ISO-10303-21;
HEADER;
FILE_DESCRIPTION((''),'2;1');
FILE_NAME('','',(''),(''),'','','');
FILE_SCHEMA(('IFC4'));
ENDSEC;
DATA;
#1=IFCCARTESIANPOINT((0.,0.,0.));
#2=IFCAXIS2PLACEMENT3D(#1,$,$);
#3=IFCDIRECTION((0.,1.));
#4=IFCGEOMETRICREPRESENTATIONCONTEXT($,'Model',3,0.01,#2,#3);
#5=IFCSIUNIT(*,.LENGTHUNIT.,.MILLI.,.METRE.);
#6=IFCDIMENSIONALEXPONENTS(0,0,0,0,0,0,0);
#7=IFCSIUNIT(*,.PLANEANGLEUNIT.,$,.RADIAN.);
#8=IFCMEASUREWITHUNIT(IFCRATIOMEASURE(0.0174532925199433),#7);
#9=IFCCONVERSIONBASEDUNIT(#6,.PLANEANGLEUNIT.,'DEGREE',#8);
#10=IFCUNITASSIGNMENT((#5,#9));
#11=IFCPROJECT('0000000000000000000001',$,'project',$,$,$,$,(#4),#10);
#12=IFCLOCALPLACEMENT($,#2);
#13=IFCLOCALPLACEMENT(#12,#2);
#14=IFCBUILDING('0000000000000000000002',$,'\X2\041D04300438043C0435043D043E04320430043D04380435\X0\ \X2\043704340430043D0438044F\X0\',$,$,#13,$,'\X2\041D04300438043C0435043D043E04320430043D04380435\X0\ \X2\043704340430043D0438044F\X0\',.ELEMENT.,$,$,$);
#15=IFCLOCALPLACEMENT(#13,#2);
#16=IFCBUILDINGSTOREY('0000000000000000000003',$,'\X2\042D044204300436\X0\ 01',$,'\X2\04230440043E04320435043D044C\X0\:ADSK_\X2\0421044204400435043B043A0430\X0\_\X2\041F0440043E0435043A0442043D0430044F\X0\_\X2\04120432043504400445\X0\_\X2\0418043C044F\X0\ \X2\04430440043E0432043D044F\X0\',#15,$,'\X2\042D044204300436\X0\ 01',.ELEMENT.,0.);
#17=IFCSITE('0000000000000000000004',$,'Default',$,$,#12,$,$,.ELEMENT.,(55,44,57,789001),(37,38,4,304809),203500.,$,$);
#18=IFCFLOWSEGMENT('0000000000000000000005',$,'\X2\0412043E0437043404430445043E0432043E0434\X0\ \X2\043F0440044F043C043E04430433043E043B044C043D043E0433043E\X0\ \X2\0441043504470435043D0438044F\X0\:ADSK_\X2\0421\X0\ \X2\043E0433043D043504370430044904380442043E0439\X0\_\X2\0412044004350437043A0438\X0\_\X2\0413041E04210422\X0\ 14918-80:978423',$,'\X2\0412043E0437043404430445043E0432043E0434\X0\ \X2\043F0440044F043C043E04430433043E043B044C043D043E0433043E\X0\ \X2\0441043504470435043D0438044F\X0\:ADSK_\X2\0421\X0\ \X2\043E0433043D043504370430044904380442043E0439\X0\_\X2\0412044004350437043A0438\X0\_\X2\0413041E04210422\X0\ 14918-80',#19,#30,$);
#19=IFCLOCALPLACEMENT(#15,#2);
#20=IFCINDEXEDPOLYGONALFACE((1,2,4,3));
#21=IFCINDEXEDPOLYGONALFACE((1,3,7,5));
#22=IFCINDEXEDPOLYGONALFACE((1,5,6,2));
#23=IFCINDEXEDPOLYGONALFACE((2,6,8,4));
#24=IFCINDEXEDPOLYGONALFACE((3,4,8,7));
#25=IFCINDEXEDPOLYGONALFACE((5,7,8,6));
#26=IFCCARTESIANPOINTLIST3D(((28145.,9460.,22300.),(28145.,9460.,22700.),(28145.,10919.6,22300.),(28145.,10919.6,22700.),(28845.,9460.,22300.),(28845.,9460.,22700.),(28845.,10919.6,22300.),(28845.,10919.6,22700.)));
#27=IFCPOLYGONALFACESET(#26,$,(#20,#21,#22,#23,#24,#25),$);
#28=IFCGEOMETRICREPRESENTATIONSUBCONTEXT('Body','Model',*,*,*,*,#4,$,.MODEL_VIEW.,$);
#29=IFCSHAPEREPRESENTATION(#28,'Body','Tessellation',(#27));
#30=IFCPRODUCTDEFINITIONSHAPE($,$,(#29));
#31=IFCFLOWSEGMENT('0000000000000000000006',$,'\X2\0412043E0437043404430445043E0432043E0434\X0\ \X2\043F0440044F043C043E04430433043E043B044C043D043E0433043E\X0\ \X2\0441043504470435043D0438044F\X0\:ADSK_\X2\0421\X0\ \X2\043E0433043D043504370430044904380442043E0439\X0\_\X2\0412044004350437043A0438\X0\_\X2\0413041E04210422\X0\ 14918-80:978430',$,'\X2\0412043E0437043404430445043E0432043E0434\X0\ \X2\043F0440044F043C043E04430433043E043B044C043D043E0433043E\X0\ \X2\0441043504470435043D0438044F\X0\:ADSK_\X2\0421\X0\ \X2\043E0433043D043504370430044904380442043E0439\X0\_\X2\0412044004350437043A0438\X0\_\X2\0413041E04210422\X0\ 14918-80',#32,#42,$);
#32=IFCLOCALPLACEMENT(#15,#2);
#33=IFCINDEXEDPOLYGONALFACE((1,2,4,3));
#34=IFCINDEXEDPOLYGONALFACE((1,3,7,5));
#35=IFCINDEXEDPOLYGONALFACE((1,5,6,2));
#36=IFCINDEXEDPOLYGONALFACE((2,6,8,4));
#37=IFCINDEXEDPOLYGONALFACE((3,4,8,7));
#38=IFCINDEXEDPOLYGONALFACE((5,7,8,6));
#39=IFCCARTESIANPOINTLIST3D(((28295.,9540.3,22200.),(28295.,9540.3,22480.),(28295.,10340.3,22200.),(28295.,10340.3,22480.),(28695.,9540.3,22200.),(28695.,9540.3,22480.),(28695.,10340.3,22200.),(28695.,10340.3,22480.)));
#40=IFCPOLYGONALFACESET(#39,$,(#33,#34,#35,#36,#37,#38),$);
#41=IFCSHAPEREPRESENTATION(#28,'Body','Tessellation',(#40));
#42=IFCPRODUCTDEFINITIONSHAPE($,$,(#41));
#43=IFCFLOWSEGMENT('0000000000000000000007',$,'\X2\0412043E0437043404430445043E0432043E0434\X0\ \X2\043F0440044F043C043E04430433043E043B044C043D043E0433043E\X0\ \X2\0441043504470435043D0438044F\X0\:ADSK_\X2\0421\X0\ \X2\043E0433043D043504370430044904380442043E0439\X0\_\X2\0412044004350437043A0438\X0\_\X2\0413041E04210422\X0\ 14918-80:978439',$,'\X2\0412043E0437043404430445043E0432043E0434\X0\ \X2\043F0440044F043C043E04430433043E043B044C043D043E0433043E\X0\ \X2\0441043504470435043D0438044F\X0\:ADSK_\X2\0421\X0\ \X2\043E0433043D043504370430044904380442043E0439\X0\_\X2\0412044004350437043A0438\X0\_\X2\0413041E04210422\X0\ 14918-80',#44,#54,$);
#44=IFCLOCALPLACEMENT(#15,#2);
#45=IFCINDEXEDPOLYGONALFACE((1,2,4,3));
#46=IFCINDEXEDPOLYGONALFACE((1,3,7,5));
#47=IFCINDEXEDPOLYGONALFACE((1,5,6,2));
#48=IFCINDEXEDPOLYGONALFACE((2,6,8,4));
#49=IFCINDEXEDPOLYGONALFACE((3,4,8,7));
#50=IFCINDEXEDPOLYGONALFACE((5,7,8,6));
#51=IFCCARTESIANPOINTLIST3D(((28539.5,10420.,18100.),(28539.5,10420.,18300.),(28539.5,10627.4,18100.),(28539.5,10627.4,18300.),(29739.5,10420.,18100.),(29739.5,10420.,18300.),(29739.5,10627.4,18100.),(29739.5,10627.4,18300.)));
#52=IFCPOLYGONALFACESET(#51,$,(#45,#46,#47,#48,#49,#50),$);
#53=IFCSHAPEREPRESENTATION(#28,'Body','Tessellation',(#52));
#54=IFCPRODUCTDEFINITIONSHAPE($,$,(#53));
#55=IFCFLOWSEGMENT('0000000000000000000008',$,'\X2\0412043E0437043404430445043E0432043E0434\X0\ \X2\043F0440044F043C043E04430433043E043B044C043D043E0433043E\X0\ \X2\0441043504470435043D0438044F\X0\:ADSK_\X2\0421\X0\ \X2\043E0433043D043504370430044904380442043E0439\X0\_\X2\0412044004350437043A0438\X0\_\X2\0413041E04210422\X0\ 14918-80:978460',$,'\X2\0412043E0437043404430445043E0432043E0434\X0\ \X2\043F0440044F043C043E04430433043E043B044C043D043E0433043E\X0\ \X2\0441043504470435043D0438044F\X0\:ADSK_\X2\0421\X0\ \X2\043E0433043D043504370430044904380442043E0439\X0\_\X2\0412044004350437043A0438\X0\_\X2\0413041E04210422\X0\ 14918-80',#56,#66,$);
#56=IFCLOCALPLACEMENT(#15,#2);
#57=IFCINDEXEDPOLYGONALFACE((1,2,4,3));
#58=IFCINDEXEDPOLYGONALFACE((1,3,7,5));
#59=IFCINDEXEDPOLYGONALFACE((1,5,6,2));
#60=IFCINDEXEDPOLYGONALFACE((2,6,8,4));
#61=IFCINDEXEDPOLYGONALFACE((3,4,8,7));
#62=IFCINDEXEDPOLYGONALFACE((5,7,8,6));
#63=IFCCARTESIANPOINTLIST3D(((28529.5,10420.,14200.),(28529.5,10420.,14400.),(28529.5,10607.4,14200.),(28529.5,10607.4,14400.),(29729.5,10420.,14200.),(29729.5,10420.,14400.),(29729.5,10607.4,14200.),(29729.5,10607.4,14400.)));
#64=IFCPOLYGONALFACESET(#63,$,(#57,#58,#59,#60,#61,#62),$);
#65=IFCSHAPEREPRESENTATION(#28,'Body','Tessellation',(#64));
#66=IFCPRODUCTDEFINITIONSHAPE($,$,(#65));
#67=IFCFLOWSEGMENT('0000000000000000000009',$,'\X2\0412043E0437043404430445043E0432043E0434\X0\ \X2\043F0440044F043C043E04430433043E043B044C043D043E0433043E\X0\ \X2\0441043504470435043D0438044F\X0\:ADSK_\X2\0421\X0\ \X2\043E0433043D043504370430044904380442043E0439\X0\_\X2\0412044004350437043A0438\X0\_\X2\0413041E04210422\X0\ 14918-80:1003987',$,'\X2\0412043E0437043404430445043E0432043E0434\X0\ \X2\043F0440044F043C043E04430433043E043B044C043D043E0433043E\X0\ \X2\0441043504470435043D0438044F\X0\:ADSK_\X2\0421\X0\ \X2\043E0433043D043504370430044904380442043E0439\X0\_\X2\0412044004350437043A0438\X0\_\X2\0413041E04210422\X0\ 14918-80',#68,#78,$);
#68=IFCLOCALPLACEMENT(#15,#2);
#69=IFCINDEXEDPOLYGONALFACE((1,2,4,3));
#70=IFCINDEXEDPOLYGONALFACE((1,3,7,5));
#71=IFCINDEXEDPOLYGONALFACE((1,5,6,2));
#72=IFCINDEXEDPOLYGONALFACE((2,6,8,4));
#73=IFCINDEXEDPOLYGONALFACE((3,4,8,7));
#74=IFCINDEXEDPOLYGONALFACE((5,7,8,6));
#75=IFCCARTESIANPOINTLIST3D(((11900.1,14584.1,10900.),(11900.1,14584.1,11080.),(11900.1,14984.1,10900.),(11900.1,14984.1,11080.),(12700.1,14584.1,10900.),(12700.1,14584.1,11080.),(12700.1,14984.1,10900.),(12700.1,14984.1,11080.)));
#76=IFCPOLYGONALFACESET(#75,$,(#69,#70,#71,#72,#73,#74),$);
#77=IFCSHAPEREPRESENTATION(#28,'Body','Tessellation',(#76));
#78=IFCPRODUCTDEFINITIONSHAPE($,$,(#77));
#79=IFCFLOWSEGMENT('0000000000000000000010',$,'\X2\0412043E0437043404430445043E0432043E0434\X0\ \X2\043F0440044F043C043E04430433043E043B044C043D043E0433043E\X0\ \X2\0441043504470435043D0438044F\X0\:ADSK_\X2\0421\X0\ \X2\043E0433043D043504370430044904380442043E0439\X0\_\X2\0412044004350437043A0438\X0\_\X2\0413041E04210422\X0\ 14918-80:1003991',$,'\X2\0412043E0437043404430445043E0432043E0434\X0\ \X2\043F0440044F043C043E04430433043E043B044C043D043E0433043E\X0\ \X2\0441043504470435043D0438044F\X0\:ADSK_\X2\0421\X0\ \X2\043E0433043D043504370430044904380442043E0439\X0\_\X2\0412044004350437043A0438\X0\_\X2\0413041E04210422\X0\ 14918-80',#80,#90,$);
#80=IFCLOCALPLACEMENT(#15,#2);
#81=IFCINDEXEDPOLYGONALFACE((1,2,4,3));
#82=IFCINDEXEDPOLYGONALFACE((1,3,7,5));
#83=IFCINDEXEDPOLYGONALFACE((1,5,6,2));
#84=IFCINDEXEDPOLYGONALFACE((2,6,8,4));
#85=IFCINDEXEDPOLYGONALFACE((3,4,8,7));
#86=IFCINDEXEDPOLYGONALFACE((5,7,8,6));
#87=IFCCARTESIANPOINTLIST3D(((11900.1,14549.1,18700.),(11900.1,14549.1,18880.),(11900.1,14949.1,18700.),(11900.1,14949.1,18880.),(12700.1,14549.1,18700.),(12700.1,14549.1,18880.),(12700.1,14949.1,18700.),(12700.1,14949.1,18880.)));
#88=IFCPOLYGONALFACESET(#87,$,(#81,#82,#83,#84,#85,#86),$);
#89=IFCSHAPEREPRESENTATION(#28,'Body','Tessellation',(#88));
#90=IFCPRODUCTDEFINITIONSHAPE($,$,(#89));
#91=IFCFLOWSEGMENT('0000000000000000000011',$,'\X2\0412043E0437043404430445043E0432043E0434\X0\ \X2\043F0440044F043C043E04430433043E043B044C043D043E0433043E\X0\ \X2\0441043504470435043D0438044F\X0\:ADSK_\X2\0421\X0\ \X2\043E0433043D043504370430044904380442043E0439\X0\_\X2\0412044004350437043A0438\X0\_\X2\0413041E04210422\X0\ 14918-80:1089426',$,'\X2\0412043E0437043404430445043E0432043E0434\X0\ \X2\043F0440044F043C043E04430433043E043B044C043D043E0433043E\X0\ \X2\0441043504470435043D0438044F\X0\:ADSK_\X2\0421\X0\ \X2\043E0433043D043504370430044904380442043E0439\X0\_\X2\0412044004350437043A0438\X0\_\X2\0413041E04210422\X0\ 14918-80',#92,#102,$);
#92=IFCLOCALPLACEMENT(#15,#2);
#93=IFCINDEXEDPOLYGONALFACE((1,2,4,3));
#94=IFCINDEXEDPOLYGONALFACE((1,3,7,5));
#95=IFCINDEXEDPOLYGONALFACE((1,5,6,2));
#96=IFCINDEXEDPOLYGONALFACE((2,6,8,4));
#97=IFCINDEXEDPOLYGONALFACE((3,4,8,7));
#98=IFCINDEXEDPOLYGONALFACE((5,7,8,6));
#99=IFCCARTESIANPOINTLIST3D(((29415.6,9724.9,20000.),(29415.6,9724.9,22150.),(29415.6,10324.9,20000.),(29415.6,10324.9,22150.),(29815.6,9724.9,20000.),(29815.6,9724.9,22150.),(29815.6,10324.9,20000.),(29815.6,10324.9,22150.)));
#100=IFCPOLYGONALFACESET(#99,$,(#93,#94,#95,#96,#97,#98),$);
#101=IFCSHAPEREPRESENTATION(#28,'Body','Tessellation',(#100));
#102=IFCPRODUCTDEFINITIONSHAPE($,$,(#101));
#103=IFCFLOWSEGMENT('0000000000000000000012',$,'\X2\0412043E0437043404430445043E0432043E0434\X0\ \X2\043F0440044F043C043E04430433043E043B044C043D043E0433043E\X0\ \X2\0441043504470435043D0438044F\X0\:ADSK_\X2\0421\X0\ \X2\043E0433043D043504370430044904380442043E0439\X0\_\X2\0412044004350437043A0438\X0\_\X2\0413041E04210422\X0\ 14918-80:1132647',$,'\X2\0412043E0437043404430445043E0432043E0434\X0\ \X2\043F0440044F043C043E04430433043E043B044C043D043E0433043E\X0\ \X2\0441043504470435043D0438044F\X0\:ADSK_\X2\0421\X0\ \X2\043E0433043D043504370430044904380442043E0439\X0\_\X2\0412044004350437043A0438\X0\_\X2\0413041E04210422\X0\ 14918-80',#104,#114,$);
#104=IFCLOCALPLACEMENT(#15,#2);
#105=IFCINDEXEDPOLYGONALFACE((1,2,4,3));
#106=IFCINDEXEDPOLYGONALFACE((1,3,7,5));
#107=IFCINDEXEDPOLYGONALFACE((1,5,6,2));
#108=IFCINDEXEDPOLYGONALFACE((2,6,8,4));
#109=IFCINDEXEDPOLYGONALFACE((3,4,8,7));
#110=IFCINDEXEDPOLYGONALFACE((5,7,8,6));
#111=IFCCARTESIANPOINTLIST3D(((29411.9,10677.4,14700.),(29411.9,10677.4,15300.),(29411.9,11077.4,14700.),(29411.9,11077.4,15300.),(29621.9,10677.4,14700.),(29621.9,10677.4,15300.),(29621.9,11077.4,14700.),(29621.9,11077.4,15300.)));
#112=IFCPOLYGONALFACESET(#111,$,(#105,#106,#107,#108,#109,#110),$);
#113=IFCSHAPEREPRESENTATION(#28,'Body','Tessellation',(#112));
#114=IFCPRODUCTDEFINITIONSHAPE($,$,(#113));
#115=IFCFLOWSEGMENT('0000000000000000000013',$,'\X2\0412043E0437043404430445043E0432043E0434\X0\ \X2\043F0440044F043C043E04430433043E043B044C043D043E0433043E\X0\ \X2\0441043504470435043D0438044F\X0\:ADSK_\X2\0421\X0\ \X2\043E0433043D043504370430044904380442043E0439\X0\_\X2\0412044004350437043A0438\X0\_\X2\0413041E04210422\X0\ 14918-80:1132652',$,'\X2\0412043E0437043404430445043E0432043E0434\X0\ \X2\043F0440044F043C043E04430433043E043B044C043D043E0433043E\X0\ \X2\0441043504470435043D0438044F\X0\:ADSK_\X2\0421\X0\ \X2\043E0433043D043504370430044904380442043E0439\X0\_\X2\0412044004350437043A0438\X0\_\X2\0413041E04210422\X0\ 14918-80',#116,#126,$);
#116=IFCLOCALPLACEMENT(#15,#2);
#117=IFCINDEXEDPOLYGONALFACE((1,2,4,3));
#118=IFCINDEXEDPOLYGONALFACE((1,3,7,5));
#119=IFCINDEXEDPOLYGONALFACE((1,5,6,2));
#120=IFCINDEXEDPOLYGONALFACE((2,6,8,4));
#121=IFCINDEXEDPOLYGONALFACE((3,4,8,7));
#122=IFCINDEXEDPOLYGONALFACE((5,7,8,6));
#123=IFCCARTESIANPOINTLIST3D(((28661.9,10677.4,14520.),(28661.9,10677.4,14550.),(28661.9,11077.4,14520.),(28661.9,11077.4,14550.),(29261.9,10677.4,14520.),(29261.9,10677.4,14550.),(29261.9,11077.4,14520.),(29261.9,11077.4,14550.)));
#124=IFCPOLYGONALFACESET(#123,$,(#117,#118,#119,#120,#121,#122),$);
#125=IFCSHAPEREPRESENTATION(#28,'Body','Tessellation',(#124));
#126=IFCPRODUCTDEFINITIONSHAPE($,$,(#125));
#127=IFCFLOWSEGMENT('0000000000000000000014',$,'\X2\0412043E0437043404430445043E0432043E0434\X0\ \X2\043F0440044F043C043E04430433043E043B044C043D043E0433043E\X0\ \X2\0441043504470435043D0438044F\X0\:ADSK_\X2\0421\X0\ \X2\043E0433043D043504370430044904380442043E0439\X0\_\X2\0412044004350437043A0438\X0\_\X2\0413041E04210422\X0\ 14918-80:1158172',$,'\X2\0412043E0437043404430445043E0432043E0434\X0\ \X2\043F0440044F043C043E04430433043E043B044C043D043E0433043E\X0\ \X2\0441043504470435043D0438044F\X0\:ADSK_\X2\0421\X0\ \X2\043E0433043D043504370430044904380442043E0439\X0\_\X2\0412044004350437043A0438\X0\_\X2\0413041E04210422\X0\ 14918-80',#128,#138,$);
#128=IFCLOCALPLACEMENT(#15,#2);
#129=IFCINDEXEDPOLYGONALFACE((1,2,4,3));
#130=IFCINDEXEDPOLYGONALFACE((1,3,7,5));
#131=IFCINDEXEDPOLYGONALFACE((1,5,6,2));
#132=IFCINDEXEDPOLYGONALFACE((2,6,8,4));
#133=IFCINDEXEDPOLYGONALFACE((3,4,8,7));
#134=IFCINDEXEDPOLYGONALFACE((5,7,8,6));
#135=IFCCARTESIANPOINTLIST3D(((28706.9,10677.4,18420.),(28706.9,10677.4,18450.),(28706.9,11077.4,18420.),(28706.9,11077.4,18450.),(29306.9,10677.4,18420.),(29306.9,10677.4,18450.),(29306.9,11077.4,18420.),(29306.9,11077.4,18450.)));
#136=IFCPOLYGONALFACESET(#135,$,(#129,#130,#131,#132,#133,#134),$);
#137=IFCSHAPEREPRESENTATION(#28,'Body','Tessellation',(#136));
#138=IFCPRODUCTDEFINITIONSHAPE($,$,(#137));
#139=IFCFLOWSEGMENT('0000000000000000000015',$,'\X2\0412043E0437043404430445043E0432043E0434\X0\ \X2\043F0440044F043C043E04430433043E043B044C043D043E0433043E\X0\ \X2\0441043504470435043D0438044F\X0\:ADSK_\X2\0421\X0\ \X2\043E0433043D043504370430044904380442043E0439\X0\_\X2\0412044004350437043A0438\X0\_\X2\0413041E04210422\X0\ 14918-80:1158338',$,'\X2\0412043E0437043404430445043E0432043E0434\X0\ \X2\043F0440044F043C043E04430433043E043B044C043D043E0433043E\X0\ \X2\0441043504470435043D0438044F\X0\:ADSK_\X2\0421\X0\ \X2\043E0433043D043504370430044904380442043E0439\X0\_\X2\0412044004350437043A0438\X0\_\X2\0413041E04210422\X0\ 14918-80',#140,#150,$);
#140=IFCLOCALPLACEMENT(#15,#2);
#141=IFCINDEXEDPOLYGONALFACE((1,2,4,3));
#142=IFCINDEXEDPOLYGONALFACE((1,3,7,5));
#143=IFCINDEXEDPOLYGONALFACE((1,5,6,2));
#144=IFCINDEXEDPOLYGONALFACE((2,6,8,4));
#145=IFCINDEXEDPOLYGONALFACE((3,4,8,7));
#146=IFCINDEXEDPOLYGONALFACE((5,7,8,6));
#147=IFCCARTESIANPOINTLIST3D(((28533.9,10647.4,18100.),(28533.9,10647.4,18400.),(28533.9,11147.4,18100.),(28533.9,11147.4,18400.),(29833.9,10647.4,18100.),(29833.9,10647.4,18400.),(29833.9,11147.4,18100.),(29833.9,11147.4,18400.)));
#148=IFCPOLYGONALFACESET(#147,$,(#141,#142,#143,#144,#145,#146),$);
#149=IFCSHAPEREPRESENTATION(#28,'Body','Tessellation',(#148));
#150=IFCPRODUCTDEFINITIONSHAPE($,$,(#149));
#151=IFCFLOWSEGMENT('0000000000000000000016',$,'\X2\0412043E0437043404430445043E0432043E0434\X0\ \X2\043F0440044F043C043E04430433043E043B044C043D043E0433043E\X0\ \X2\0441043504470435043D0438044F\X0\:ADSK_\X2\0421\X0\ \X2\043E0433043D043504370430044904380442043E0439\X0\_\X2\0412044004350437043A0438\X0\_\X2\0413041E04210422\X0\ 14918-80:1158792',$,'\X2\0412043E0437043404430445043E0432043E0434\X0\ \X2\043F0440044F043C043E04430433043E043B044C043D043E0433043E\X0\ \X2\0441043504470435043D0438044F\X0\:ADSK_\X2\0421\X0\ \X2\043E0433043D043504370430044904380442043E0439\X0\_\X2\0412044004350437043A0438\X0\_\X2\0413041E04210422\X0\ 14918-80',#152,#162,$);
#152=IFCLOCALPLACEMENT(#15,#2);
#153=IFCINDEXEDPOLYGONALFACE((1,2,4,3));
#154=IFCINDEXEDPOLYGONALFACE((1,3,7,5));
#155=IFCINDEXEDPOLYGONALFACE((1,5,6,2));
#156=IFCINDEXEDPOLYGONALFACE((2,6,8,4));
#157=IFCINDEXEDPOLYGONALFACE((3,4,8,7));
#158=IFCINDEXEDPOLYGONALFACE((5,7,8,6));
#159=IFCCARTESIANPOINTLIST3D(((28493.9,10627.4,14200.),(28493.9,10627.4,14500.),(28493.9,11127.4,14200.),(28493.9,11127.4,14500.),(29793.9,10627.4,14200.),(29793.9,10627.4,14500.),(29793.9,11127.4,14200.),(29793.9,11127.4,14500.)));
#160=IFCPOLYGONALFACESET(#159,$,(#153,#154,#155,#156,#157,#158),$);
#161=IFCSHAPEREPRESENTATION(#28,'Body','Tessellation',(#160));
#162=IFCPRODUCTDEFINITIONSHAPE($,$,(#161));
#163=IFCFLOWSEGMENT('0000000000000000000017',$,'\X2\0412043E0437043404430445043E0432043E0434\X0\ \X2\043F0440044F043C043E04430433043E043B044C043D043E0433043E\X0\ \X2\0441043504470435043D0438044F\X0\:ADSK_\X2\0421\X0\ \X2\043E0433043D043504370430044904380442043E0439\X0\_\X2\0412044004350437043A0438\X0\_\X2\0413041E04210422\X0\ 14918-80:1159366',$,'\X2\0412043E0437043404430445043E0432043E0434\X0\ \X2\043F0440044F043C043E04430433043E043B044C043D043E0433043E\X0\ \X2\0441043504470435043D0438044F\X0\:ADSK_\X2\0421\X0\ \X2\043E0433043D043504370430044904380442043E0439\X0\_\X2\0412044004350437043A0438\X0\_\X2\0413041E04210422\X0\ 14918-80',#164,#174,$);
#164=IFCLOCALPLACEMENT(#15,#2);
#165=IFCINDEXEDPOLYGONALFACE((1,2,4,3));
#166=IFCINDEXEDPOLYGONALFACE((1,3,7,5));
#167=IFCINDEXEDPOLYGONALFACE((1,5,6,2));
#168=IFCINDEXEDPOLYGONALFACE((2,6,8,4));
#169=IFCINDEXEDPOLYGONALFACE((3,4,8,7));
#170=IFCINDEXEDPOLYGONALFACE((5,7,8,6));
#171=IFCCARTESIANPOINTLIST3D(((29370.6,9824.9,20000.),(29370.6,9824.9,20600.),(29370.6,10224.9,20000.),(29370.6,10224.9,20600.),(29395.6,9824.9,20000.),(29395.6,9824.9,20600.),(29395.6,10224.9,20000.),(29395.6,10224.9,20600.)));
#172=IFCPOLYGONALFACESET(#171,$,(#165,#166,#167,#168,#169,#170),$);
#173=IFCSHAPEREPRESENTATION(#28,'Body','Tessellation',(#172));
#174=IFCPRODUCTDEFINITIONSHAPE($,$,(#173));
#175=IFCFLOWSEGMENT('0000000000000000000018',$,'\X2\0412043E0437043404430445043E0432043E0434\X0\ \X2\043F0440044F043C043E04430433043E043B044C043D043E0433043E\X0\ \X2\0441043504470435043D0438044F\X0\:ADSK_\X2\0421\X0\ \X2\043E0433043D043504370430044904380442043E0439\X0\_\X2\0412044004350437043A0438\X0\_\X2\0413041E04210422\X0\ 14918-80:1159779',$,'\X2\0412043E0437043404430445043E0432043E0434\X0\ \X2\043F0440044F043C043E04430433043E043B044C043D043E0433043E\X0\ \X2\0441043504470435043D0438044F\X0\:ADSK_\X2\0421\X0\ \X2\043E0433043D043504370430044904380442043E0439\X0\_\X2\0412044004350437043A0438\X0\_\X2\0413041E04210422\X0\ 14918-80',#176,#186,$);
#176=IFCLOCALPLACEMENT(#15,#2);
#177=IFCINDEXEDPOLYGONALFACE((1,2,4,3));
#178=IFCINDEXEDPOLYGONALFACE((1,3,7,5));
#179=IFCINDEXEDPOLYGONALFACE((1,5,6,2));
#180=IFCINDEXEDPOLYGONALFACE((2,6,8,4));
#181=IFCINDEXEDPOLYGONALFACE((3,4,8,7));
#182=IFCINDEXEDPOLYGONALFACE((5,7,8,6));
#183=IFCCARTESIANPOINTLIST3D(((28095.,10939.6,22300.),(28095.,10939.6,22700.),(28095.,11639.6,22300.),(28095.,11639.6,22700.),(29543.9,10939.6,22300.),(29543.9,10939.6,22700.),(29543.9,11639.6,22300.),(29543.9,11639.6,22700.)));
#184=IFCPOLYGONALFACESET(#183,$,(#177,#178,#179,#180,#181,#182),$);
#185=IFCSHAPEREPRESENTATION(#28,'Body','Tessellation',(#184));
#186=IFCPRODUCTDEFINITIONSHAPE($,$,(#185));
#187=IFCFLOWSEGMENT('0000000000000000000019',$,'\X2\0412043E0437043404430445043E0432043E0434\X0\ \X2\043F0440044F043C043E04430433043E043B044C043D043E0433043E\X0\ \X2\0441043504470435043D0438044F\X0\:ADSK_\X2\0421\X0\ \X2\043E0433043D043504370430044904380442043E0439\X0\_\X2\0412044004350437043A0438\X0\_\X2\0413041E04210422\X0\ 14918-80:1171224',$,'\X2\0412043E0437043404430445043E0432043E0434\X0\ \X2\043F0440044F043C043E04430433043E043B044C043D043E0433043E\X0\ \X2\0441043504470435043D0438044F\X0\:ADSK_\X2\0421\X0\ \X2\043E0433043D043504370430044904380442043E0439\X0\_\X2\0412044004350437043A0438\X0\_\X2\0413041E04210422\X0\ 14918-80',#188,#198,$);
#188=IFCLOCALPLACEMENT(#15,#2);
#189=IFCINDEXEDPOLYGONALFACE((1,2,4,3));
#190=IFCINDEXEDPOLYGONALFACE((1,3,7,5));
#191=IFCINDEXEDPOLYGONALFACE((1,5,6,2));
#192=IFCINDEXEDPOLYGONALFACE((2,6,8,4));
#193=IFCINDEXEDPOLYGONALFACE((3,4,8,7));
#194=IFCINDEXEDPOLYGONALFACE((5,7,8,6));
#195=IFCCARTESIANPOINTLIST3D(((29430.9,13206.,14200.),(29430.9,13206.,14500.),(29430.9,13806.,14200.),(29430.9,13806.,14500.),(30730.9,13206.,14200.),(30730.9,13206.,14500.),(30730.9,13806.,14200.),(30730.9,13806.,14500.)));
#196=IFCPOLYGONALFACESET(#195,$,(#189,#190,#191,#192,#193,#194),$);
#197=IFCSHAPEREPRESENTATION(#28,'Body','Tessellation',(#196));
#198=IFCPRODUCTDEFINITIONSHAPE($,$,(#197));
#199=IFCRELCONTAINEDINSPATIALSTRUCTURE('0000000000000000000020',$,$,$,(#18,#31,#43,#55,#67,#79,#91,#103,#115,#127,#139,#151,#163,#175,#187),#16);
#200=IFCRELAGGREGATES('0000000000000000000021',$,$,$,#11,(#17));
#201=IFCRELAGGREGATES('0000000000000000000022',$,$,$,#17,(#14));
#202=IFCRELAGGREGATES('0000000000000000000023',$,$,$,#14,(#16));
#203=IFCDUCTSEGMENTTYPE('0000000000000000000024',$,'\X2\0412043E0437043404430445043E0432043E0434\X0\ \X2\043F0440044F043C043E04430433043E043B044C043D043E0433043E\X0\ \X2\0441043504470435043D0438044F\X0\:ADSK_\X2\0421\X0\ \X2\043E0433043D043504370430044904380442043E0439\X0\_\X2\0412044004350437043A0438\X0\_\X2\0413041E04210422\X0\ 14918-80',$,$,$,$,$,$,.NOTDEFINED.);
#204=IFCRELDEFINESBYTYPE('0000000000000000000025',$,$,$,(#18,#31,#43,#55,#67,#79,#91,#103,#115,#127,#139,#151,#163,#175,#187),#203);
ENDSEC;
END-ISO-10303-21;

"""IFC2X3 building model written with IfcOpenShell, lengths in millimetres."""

from ifc_helpers import new_model, entity, si_unit, converted_unit, direction, frame, frame_2d, origin, origin_2d_with_axis, place, context, subcontext, project, spatial, rectangle, extrude, type_object, element, save


model = new_model("IFC2X3")

# Units and contexts
model_context = context("Model", 3, precision=0.01, world=origin(), true_north=direction((0.0, 1.0)))
body_context = subcontext(model_context, "Body", "Model", "MODEL_VIEW")
ifc_project = project(units=[si_unit("LENGTHUNIT", "METRE", prefix="MILLI"), converted_unit("PLANEANGLEUNIT", "DEGREE", entity("IfcRatioMeasure", 0.0174532925199433), si_unit("PLANEANGLEUNIT", "RADIAN"), dimensions=[0, 0, 0, 0, 0, 0, 0])], contexts=[model_context])

# Site, building, storey
site_placement = place(None, frame((0.0, 0.0, 0.0)))
site = spatial("IfcSite", under=ifc_project, at=site_placement, Name="Default", CompositionType="ELEMENT", RefLatitude=(55, 44, 57, 789001), RefLongitude=(37, 38, 4, 304809), RefElevation=203500.0)
building_placement = place(site_placement, origin())
building = spatial("IfcBuilding", under=site, at=building_placement, Name="Наименование здания", LongName="Наименование здания", CompositionType="ELEMENT")
storey_placement = place(building_placement, origin())
storey = spatial("IfcBuildingStorey", under=building, at=storey_placement, Name="Этаж 01", ObjectType="Уровень:ADSK_Стрелка_Проектная_Вверх_Имя уровня", LongName="Этаж 01", CompositionType="ELEMENT", Elevation=0.0)

# Flow segments
duct_segment_type = type_object("IfcDuctSegmentType", Name="Воздуховод прямоугольного сечения:ADSK_С огнезащитой_Врезки_ГОСТ 14918-80", PredefinedType="NOTDEFINED")
flow_segment_1_placement = place(storey_placement, frame((28145.0, 9460.0, 22300.0)))
element("IfcFlowSegment", 1, at=flow_segment_1_placement, inside=storey, type_object=duct_segment_type, Name="Воздуховод прямоугольного сечения:ADSK_С огнезащитой_Врезки_ГОСТ 14918-80:978423", ObjectType="Воздуховод прямоугольного сечения:ADSK_С огнезащитой_Врезки_ГОСТ 14918-80", context=body_context, shape_type="SweptSolid", body=[
    extrude(rectangle(XDim=1459.6, YDim=700.0, at=frame_2d((0.0, 0.0), x_axis=(1.0, 0.0))), frame((350.0, 729.8, 0.0), z_axis=(0.0, 0.0, 1.0), x_axis=(0.0, 1.0, 0.0)), (0.0, 0.0, 1.0), 400.0),
])
flow_segment_2_placement = place(storey_placement, frame((28295.0, 9540.3, 22200.0)))
element("IfcFlowSegment", 2, at=flow_segment_2_placement, inside=storey, type_object=duct_segment_type, Name="Воздуховод прямоугольного сечения:ADSK_С огнезащитой_Врезки_ГОСТ 14918-80:978430", ObjectType="Воздуховод прямоугольного сечения:ADSK_С огнезащитой_Врезки_ГОСТ 14918-80", context=body_context, shape_type="SweptSolid", body=[
    extrude(rectangle(XDim=800.0, YDim=400.0, at=frame_2d((0.0, 0.0), x_axis=(1.0, 0.0))), frame((200.0, 400.0, 0.0), z_axis=(0.0, 0.0, 1.0), x_axis=(0.0, 1.0, 0.0)), (0.0, 0.0, 1.0), 280.0),
])
flow_segment_3_placement = place(storey_placement, frame((28539.5, 10420.0, 18100.0)))
element("IfcFlowSegment", 3, at=flow_segment_3_placement, inside=storey, type_object=duct_segment_type, Name="Воздуховод прямоугольного сечения:ADSK_С огнезащитой_Врезки_ГОСТ 14918-80:978439", ObjectType="Воздуховод прямоугольного сечения:ADSK_С огнезащитой_Врезки_ГОСТ 14918-80", context=body_context, shape_type="SweptSolid", body=[
    extrude(rectangle(XDim=207.4, YDim=1200.0, at=frame_2d((0.0, 0.0), x_axis=(1.0, 0.0))), frame((600.0, 103.7, 0.0), z_axis=(0.0, 0.0, 1.0), x_axis=(0.0, 1.0, 0.0)), (0.0, 0.0, 1.0), 200.0),
])
flow_segment_4_placement = place(storey_placement, frame((28529.5, 10420.0, 14200.0)))
element("IfcFlowSegment", 4, at=flow_segment_4_placement, inside=storey, type_object=duct_segment_type, Name="Воздуховод прямоугольного сечения:ADSK_С огнезащитой_Врезки_ГОСТ 14918-80:978460", ObjectType="Воздуховод прямоугольного сечения:ADSK_С огнезащитой_Врезки_ГОСТ 14918-80", context=body_context, shape_type="SweptSolid", body=[
    extrude(rectangle(XDim=187.4, YDim=1200.0, at=frame_2d((0.0, 0.0), x_axis=(1.0, 0.0))), frame((600.0, 93.7, 0.0), z_axis=(0.0, 0.0, 1.0), x_axis=(0.0, 1.0, 0.0)), (0.0, 0.0, 1.0), 200.0),
])
flow_segment_5_placement = place(storey_placement, frame((11900.1, 14584.1, 10900.0)))
element("IfcFlowSegment", 5, at=flow_segment_5_placement, inside=storey, type_object=duct_segment_type, Name="Воздуховод прямоугольного сечения:ADSK_С огнезащитой_Врезки_ГОСТ 14918-80:1003987", ObjectType="Воздуховод прямоугольного сечения:ADSK_С огнезащитой_Врезки_ГОСТ 14918-80", context=body_context, shape_type="SweptSolid", body=[
    extrude(rectangle(XDim=400.0, YDim=800.0, at=frame_2d((0.0, 0.0), x_axis=(1.0, 0.0))), frame((400.0, 200.0, 0.0), z_axis=(0.0, 0.0, 1.0), x_axis=(0.0, 1.0, 0.0)), (0.0, 0.0, 1.0), 180.0),
])
flow_segment_6_placement = place(storey_placement, frame((11900.1, 14549.1, 18700.0)))
element("IfcFlowSegment", 6, at=flow_segment_6_placement, inside=storey, type_object=duct_segment_type, Name="Воздуховод прямоугольного сечения:ADSK_С огнезащитой_Врезки_ГОСТ 14918-80:1003991", ObjectType="Воздуховод прямоугольного сечения:ADSK_С огнезащитой_Врезки_ГОСТ 14918-80", context=body_context, shape_type="SweptSolid", body=[
    extrude(rectangle(XDim=800.0, YDim=400.0, at=origin_2d_with_axis()), frame((400.0, 200.0, 0.0)), (0.0, 0.0, 1.0), 180.0),
])
flow_segment_7_placement = place(storey_placement, frame((29415.6, 9724.9, 20000.0)))
element("IfcFlowSegment", 7, at=flow_segment_7_placement, inside=storey, type_object=duct_segment_type, Name="Воздуховод прямоугольного сечения:ADSK_С огнезащитой_Врезки_ГОСТ 14918-80:1089426", ObjectType="Воздуховод прямоугольного сечения:ADSK_С огнезащитой_Врезки_ГОСТ 14918-80", context=body_context, shape_type="SweptSolid", body=[
    extrude(rectangle(XDim=600.0, YDim=400.0, at=frame_2d((0.0, 0.0), x_axis=(1.0, 0.0))), frame((200.0, 300.0, 0.0), z_axis=(0.0, 0.0, 1.0), x_axis=(0.0, 1.0, 0.0)), (0.0, 0.0, 1.0), 2150.0),
])
flow_segment_8_placement = place(storey_placement, frame((29411.9, 10677.4, 14700.0)))
element("IfcFlowSegment", 8, at=flow_segment_8_placement, inside=storey, type_object=duct_segment_type, Name="Воздуховод прямоугольного сечения:ADSK_С огнезащитой_Врезки_ГОСТ 14918-80:1132647", ObjectType="Воздуховод прямоугольного сечения:ADSK_С огнезащитой_Врезки_ГОСТ 14918-80", context=body_context, shape_type="SweptSolid", body=[
    extrude(rectangle(XDim=210.0, YDim=400.0, at=frame_2d((0.0, 0.0), x_axis=(1.0, 0.0))), frame((105.0, 200.0, 0.0), z_axis=(0.0, 0.0, 1.0), x_axis=(-1.0, 0.0, 0.0)), (0.0, 0.0, 1.0), 600.0),
])
flow_segment_9_placement = place(storey_placement, frame((28661.9, 10677.4, 14520.0)))
element("IfcFlowSegment", 9, at=flow_segment_9_placement, inside=storey, type_object=duct_segment_type, Name="Воздуховод прямоугольного сечения:ADSK_С огнезащитой_Врезки_ГОСТ 14918-80:1132652", ObjectType="Воздуховод прямоугольного сечения:ADSK_С огнезащитой_Врезки_ГОСТ 14918-80", context=body_context, shape_type="SweptSolid", body=[
    extrude(rectangle(XDim=400.0, YDim=600.0, at=frame_2d((0.0, 0.0), x_axis=(1.0, 0.0))), frame((300.0, 200.0, 0.0), z_axis=(0.0, 0.0, 1.0), x_axis=(0.0, 1.0, 0.0)), (0.0, 0.0, 1.0), 30.0),
])
flow_segment_10_placement = place(storey_placement, frame((28706.9, 10677.4, 18420.0)))
element("IfcFlowSegment", 10, at=flow_segment_10_placement, inside=storey, type_object=duct_segment_type, Name="Воздуховод прямоугольного сечения:ADSK_С огнезащитой_Врезки_ГОСТ 14918-80:1158172", ObjectType="Воздуховод прямоугольного сечения:ADSK_С огнезащитой_Врезки_ГОСТ 14918-80", context=body_context, shape_type="SweptSolid", body=[
    extrude(rectangle(XDim=400.0, YDim=600.0, at=origin_2d_with_axis()), frame((300.0, 200.0, 0.0), z_axis=(0.0, 0.0, 1.0), x_axis=(0.0, 1.0, 0.0)), (0.0, 0.0, 1.0), 30.0),
])
flow_segment_11_placement = place(storey_placement, frame((28533.9, 10647.4, 18100.0)))
element("IfcFlowSegment", 11, at=flow_segment_11_placement, inside=storey, type_object=duct_segment_type, Name="Воздуховод прямоугольного сечения:ADSK_С огнезащитой_Врезки_ГОСТ 14918-80:1158338", ObjectType="Воздуховод прямоугольного сечения:ADSK_С огнезащитой_Врезки_ГОСТ 14918-80", context=body_context, shape_type="SweptSolid", body=[
    extrude(rectangle(XDim=1300.0, YDim=500.0, at=frame_2d((0.0, 0.0), x_axis=(1.0, 0.0))), frame((650.0, 250.0, 0.0), z_axis=(0.0, 0.0, 1.0), x_axis=(-1.0, 0.0, 0.0)), (0.0, 0.0, 1.0), 300.0),
])
flow_segment_12_placement = place(storey_placement, frame((28493.9, 10627.4, 14200.0)))
element("IfcFlowSegment", 12, at=flow_segment_12_placement, inside=storey, type_object=duct_segment_type, Name="Воздуховод прямоугольного сечения:ADSK_С огнезащитой_Врезки_ГОСТ 14918-80:1158792", ObjectType="Воздуховод прямоугольного сечения:ADSK_С огнезащитой_Врезки_ГОСТ 14918-80", context=body_context, shape_type="SweptSolid", body=[
    extrude(rectangle(XDim=1300.0, YDim=500.0, at=frame_2d((0.0, 0.0), x_axis=(1.0, 0.0))), frame((650.0, 250.0, 0.0), z_axis=(0.0, 0.0, 1.0), x_axis=(-1.0, 0.0, 0.0)), (0.0, 0.0, 1.0), 300.0),
])
flow_segment_13_placement = place(storey_placement, frame((29370.6, 9824.9, 20000.0)))
element("IfcFlowSegment", 13, at=flow_segment_13_placement, inside=storey, type_object=duct_segment_type, Name="Воздуховод прямоугольного сечения:ADSK_С огнезащитой_Врезки_ГОСТ 14918-80:1159366", ObjectType="Воздуховод прямоугольного сечения:ADSK_С огнезащитой_Врезки_ГОСТ 14918-80", context=body_context, shape_type="SweptSolid", body=[
    extrude(rectangle(XDim=25.0, YDim=400.0, at=frame_2d((0.0, 0.0), x_axis=(1.0, 0.0))), frame((12.5, 200.0, 0.0), z_axis=(0.0, 0.0, 1.0), x_axis=(-1.0, 0.0, 0.0)), (0.0, 0.0, 1.0), 600.0),
])
flow_segment_14_placement = place(storey_placement, frame((28095.0, 10939.6, 22300.0)))
element("IfcFlowSegment", 14, at=flow_segment_14_placement, inside=storey, type_object=duct_segment_type, Name="Воздуховод прямоугольного сечения:ADSK_С огнезащитой_Врезки_ГОСТ 14918-80:1159779", ObjectType="Воздуховод прямоугольного сечения:ADSK_С огнезащитой_Врезки_ГОСТ 14918-80", context=body_context, shape_type="SweptSolid", body=[
    extrude(rectangle(XDim=1448.9, YDim=700.0, at=frame_2d((0.0, 0.0), x_axis=(1.0, 0.0))), frame((724.5, 350.0, 0.0), z_axis=(0.0, 0.0, 1.0), x_axis=(-1.0, 0.0, 0.0)), (0.0, 0.0, 1.0), 400.0),
])
flow_segment_15_placement = place(storey_placement, frame((29430.9, 13206.0, 14200.0)))
element("IfcFlowSegment", 15, at=flow_segment_15_placement, inside=storey, type_object=duct_segment_type, Name="Воздуховод прямоугольного сечения:ADSK_С огнезащитой_Врезки_ГОСТ 14918-80:1171224", ObjectType="Воздуховод прямоугольного сечения:ADSK_С огнезащитой_Врезки_ГОСТ 14918-80", context=body_context, shape_type="SweptSolid", body=[
    extrude(rectangle(XDim=1300.0, YDim=600.0, at=frame_2d((0.0, 0.0), x_axis=(1.0, 0.0))), frame((650.0, 300.0, 0.0), z_axis=(0.0, 0.0, 1.0), x_axis=(-1.0, 0.0, 0.0)), (0.0, 0.0, 1.0), 300.0),
])

save(model, "model.ifc")
